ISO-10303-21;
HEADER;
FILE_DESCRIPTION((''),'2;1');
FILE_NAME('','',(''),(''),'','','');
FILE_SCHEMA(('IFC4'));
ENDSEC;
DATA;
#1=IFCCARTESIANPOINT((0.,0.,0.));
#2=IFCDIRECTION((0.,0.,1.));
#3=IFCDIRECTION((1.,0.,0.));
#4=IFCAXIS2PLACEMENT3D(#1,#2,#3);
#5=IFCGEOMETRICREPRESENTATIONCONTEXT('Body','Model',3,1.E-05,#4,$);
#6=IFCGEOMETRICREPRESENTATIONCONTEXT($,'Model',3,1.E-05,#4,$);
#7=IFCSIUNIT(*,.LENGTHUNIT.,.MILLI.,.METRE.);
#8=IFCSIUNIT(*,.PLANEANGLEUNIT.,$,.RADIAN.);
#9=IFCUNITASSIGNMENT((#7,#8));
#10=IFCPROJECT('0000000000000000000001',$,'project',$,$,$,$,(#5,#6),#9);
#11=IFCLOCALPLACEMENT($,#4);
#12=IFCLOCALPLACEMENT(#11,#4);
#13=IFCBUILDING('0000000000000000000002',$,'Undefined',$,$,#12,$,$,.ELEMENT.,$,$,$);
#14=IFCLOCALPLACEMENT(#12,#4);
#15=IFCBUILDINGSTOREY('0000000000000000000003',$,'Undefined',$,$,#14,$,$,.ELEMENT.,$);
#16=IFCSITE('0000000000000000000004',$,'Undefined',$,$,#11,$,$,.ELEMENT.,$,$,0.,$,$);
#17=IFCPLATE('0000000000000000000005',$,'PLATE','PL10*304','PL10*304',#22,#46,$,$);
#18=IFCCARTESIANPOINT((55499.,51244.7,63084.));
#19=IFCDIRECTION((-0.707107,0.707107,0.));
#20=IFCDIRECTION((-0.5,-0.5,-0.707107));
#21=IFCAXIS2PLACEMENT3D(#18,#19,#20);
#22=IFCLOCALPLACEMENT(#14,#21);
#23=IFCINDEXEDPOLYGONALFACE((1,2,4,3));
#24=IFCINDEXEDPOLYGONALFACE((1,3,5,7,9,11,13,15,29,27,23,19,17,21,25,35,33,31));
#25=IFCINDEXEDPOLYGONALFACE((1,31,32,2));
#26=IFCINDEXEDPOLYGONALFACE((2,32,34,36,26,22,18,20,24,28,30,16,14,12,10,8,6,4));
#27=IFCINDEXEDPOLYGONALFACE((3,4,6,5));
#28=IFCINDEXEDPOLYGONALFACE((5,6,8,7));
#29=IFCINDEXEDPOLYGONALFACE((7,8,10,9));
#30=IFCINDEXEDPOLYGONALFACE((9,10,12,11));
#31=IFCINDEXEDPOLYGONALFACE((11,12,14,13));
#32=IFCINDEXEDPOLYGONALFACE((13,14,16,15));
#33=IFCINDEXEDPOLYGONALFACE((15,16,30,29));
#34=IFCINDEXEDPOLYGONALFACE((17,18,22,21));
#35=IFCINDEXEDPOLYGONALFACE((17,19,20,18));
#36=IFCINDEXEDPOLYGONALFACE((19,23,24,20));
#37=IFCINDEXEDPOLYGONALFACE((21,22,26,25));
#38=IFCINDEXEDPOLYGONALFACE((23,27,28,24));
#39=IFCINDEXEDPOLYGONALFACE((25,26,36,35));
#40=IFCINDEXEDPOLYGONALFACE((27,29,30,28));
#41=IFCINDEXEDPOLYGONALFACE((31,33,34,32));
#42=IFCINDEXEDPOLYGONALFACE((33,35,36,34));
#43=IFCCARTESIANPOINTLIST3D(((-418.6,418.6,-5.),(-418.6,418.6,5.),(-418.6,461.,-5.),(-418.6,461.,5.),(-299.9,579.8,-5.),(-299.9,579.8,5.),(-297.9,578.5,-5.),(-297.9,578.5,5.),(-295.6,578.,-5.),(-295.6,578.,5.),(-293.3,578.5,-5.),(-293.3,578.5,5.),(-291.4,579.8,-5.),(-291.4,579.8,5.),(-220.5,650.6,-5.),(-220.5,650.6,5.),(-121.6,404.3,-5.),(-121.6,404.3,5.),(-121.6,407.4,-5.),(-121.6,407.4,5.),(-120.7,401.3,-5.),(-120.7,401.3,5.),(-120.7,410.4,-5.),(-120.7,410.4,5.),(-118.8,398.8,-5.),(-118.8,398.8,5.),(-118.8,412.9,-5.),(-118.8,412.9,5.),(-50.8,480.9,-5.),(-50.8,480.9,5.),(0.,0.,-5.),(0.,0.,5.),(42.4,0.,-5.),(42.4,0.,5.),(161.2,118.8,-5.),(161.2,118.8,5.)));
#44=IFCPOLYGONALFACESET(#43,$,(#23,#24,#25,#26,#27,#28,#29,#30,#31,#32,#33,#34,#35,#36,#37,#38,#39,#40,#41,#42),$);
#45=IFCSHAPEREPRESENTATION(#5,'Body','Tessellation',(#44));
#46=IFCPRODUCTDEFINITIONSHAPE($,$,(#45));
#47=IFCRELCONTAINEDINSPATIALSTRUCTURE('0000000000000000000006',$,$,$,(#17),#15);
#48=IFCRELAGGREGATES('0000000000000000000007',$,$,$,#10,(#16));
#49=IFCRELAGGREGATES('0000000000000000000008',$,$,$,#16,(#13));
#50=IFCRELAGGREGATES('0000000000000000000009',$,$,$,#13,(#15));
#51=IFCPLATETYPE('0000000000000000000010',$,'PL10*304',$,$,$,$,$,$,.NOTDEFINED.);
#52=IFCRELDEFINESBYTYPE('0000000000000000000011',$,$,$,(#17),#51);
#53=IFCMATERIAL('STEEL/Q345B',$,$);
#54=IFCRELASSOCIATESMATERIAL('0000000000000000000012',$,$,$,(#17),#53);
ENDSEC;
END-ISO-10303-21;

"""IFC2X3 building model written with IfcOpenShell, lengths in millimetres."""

from ifc_helpers import new_model, si_unit, frame, origin_with_axes, place, context, project, spatial, polyline, outline, extrude, material, type_object, element, save


model = new_model("IFC2X3")

# Units and contexts
model_context_1 = context("Model", 3, precision=1e-05, world=origin_with_axes(), identifier="Body")
model_context_2 = context("Model", 3, precision=1e-05, world=origin_with_axes())
ifc_project = project(units=[si_unit("LENGTHUNIT", "METRE", prefix="MILLI"), si_unit("PLANEANGLEUNIT", "RADIAN")], contexts=[model_context_1, model_context_2])

# Site, building, storey
site_placement = place(None, origin_with_axes())
site = spatial("IfcSite", under=ifc_project, at=site_placement, Name="Undefined", CompositionType="ELEMENT", RefElevation=0.0)
building_placement = place(site_placement, origin_with_axes())
building = spatial("IfcBuilding", under=site, at=building_placement, Name="Undefined", CompositionType="ELEMENT")
storey_placement = place(building_placement, origin_with_axes())
storey = spatial("IfcBuildingStorey", under=building, at=storey_placement, Name="Undefined", CompositionType="ELEMENT")

# Shared definitions
ifc_material_1 = material(Name="STEEL/Q345B")

# Plate
plate_type_1 = type_object("IfcPlateType", Name="PL10*304", PredefinedType="NOTDEFINED")
plate_1_placement = place(storey_placement, frame((55499.0, 51244.7, 63084.0), z_axis=(-0.707107, 0.707107, 0.0), x_axis=(-0.5, -0.5, -0.707107)))
element("IfcPlate", 1, at=plate_1_placement, inside=storey, type_object=plate_type_1, material=ifc_material_1, Name="PLATE", Description="PL10*304", ObjectType="PL10*304", context=model_context_1, shape_type="SweptSolid", body=[
    extrude(outline(polyline([(0.0, 0.0), (42.4, 0.0), (161.2, 118.8), (-118.8, 398.8), (-120.7, 401.3), (-121.6, 404.3), (-121.6, 407.4), (-120.7, 410.4), (-118.8, 412.9), (-50.8, 480.9), (-220.5, 650.6), (-291.4, 579.8), (-293.3, 578.5), (-295.6, 578.0), (-297.9, 578.5), (-299.9, 579.8), (-418.6, 461.0), (-418.6, 418.6), (0.0, 0.0)])), frame((0.0, 0.0, -5.0), z_axis=(0.0, 0.0, 1.0), x_axis=(1.0, 0.0, 0.0)), (0.0, 0.0, 1.0), 10.0),
])

save(model, "model.ifc")
